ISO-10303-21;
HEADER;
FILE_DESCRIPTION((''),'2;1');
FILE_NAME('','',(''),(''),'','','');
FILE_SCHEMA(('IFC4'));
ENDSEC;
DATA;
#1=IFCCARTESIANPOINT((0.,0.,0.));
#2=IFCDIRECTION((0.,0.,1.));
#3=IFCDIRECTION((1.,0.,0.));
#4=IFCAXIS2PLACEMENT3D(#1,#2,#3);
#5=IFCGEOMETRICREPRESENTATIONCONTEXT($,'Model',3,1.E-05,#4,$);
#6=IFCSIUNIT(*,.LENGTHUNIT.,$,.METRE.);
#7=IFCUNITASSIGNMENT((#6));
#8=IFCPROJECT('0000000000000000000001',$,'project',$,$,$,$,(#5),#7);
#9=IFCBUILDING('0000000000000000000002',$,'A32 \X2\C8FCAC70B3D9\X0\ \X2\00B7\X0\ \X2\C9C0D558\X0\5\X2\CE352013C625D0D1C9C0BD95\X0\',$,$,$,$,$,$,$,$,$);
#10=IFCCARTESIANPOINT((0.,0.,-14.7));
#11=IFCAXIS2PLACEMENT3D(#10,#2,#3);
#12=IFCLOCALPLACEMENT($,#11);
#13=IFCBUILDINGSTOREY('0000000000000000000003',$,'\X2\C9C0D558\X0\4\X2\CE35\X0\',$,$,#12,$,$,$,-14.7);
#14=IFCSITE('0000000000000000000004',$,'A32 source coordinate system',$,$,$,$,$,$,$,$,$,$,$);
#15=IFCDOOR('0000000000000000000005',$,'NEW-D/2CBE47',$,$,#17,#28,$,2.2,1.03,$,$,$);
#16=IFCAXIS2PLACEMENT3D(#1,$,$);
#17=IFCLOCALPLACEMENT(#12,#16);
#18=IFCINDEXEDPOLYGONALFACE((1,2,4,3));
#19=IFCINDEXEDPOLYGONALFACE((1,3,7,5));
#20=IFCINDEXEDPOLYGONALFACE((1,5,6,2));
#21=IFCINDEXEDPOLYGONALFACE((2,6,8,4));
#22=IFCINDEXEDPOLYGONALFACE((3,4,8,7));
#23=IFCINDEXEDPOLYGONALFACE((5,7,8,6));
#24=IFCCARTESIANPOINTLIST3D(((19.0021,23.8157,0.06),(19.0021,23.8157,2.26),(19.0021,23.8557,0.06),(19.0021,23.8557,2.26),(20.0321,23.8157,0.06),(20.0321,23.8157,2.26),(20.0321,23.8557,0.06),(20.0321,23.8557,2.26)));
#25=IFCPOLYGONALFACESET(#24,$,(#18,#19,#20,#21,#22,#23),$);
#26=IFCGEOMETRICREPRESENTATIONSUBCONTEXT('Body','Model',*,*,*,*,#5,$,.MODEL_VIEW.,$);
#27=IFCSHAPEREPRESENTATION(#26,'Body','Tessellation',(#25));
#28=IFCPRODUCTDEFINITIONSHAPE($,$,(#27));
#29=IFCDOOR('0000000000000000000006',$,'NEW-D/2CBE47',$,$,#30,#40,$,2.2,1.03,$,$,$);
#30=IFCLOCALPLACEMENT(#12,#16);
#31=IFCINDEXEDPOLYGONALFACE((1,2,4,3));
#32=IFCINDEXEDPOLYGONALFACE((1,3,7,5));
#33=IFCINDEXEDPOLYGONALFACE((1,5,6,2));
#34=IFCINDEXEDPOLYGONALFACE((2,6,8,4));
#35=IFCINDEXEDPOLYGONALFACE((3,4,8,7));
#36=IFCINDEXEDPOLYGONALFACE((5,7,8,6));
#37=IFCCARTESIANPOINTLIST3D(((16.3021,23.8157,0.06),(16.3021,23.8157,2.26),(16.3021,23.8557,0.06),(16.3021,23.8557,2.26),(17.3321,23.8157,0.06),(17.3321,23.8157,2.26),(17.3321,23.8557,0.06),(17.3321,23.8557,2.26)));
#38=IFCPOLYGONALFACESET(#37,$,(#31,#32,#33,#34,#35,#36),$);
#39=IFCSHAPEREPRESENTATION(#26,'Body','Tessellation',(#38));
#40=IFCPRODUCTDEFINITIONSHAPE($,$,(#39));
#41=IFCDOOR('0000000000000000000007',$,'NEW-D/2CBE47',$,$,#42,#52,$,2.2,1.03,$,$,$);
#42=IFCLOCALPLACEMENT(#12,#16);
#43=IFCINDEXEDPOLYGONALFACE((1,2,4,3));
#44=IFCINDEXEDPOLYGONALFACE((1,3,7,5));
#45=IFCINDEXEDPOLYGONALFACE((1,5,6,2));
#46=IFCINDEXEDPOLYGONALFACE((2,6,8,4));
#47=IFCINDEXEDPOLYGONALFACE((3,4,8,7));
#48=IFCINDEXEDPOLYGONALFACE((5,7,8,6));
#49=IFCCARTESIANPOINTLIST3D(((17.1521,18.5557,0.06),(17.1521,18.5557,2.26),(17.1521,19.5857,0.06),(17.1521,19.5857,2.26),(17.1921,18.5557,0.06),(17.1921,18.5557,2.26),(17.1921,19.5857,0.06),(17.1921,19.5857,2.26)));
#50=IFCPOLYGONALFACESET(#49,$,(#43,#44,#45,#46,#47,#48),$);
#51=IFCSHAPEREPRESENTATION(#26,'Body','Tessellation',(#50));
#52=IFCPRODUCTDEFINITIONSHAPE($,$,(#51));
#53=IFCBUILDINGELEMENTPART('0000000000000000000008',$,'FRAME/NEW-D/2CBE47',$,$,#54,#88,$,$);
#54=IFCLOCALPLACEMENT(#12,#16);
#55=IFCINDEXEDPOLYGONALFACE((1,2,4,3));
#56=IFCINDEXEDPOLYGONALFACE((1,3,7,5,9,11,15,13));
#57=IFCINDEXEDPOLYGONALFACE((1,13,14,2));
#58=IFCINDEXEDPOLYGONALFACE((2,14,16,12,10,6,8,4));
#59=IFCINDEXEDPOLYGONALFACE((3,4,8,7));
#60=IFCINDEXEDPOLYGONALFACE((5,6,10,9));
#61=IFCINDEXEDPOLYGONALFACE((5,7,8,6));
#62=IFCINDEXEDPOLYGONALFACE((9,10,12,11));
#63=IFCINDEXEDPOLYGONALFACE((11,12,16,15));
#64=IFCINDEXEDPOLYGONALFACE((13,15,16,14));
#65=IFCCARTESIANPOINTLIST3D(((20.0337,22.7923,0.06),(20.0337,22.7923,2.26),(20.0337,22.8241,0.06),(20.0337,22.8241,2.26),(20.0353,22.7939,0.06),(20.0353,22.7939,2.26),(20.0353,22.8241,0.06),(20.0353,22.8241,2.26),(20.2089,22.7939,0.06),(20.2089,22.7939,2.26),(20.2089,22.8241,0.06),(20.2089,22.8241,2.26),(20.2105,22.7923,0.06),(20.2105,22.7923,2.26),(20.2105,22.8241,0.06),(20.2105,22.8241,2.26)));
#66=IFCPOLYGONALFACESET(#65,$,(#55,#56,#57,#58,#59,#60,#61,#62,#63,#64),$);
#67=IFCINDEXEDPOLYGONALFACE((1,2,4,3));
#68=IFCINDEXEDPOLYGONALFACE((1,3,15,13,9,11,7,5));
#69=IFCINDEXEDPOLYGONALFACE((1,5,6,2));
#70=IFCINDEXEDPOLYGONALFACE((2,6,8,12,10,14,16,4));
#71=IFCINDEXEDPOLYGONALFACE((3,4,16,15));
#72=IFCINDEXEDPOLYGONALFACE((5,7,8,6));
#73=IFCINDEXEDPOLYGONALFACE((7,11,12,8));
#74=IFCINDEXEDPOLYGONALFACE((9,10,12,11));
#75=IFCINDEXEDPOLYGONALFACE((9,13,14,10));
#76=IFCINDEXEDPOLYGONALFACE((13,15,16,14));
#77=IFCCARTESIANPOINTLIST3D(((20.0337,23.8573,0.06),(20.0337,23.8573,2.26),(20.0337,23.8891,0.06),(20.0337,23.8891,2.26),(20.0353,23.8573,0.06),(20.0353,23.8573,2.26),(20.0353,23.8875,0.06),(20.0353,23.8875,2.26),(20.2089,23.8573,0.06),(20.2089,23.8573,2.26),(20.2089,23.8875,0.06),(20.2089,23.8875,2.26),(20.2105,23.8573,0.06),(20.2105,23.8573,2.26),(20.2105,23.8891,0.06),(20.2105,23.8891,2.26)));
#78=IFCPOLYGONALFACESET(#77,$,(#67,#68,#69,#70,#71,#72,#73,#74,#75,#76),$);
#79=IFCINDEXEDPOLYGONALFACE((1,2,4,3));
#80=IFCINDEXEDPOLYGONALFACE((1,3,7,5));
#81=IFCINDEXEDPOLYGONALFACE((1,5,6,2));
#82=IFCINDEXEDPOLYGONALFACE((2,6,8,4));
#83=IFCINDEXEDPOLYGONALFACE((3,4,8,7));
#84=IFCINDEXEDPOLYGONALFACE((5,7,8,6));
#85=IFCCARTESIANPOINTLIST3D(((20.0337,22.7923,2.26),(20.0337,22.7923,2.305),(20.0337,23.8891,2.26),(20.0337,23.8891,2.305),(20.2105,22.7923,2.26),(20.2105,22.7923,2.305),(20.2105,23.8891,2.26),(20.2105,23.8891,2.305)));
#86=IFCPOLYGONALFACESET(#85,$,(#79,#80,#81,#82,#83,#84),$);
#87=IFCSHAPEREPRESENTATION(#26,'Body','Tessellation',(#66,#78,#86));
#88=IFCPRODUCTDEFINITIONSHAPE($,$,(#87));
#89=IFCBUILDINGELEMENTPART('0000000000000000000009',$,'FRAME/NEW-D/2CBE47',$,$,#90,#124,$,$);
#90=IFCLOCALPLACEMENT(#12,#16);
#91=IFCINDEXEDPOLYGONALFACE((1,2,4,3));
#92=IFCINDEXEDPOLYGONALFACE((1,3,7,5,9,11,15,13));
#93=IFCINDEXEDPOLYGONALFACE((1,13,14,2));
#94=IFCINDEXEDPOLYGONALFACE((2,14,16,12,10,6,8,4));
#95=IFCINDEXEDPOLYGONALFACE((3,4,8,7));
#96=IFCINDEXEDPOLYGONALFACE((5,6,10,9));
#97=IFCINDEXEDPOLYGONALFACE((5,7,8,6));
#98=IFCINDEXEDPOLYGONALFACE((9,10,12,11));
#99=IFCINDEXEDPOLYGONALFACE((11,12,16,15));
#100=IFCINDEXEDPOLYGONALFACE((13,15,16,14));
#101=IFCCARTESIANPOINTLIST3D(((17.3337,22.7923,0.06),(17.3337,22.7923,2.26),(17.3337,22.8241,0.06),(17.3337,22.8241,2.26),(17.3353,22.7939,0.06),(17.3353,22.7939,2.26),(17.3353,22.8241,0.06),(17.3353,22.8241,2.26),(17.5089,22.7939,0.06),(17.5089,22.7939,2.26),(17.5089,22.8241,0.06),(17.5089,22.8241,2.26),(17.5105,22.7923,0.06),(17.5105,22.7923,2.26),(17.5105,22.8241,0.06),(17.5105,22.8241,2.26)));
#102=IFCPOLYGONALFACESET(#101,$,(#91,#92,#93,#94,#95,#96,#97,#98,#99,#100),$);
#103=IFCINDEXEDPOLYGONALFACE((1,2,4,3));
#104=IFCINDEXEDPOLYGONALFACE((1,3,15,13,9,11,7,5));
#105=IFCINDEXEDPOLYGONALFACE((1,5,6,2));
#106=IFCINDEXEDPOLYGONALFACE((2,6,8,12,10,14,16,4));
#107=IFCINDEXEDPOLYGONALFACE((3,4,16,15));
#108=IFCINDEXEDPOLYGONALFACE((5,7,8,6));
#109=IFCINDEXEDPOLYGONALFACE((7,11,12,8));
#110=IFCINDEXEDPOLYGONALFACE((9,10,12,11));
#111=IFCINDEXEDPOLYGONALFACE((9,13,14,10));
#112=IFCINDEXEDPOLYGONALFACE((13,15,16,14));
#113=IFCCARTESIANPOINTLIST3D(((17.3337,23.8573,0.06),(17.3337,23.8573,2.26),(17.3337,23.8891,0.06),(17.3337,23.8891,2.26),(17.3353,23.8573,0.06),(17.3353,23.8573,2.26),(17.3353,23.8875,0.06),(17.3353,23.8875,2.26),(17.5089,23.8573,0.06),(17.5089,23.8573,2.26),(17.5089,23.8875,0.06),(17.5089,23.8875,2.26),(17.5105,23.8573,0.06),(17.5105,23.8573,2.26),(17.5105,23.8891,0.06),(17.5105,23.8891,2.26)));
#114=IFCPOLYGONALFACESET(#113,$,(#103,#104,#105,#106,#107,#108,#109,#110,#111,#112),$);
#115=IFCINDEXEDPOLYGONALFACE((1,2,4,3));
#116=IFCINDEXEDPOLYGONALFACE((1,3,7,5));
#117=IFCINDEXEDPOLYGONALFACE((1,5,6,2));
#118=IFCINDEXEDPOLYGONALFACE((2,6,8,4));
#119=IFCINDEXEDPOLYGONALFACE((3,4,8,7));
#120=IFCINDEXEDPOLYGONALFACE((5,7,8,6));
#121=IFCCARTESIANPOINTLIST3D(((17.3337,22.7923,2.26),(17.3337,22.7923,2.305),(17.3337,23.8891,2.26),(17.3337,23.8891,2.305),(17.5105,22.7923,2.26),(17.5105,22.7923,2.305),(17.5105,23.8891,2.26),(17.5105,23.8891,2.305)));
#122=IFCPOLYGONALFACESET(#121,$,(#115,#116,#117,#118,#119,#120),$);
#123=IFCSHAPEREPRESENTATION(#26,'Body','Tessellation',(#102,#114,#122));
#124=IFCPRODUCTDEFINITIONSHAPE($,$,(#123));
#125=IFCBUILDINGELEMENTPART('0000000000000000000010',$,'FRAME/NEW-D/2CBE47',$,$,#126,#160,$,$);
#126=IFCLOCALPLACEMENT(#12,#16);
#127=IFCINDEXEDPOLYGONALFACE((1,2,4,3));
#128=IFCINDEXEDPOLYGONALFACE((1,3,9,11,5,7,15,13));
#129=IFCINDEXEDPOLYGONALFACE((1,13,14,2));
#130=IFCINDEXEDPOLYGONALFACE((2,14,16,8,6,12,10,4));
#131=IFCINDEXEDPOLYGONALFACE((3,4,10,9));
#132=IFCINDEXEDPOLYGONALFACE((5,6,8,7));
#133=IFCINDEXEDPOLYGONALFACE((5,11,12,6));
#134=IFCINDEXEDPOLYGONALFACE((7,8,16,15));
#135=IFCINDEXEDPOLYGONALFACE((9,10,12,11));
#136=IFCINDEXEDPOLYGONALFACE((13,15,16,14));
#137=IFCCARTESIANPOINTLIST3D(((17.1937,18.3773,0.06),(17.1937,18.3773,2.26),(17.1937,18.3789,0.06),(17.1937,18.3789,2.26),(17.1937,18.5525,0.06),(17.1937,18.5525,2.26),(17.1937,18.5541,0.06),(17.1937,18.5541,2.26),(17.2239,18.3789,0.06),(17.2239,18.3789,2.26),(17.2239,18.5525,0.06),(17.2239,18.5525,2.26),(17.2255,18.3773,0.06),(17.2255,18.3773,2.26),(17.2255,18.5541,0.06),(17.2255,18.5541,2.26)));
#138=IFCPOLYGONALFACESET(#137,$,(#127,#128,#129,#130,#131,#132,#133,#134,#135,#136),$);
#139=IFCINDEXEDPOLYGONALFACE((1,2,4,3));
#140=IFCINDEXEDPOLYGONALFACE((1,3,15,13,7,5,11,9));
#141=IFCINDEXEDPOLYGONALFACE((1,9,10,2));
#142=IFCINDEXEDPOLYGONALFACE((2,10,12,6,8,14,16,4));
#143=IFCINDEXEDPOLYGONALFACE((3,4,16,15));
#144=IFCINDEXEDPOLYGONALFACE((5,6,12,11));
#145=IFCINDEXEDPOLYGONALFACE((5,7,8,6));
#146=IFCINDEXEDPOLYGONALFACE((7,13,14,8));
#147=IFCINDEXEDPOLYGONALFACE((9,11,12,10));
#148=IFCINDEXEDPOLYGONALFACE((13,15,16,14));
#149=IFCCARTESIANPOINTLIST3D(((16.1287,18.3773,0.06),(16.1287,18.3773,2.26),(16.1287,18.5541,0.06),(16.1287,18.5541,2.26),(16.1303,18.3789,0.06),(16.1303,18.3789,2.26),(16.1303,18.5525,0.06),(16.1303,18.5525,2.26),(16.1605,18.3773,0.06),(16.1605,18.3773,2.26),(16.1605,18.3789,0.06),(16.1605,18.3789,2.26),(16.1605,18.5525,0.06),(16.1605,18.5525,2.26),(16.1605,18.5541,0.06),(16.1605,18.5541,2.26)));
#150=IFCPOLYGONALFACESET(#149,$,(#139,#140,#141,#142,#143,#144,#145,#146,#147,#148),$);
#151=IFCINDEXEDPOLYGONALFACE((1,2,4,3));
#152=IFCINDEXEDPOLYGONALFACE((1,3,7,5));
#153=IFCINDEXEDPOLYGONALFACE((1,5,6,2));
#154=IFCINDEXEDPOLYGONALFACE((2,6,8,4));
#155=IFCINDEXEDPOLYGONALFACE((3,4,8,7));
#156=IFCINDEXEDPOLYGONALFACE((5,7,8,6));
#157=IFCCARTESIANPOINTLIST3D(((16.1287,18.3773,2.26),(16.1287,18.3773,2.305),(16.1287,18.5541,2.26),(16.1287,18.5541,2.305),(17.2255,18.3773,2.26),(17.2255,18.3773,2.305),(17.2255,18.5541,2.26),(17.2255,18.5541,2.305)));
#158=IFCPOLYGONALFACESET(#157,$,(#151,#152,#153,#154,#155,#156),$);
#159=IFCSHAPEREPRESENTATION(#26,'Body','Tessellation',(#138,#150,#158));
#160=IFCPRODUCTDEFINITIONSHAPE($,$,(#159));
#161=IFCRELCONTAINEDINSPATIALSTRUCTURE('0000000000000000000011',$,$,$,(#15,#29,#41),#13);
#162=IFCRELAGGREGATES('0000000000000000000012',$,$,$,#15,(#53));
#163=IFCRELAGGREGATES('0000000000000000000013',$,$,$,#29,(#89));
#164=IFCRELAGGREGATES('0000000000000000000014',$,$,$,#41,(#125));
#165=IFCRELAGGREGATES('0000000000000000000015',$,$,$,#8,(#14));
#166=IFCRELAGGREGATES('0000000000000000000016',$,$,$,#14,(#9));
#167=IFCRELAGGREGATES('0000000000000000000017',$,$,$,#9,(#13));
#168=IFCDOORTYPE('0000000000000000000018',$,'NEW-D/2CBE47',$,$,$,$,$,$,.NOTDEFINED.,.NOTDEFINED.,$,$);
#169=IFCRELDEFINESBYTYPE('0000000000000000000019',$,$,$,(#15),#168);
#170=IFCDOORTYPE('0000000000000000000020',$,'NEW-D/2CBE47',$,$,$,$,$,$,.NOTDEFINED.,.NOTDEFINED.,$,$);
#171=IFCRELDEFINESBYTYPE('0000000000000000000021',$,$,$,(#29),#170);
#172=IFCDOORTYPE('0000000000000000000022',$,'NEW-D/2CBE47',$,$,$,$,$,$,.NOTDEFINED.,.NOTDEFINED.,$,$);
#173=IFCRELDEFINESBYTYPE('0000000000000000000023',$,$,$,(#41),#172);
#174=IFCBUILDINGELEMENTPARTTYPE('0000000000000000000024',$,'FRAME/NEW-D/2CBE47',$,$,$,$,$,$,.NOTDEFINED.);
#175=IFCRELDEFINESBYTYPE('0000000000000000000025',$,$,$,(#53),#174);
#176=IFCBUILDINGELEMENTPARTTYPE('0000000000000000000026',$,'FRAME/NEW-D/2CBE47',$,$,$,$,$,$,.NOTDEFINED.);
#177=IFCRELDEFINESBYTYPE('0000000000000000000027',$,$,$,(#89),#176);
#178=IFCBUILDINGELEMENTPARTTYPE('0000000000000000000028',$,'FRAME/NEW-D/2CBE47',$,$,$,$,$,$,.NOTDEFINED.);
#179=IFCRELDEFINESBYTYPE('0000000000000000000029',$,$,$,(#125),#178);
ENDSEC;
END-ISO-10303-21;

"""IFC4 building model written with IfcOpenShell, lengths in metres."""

from ifc_helpers import new_model, si_unit, frame, origin, origin_with_axes, place, context, subcontext, project, spatial, polyline, outline, extrude, source, transform, mapped, type_object, type_shapes, element, aggregate, save


model = new_model("IFC4")

# Units and contexts
model_context = context("Model", 3, precision=1e-05, world=origin_with_axes())
body_context = subcontext(model_context, "Body", "Model", "MODEL_VIEW")
ifc_project = project(units=[si_unit("LENGTHUNIT", "METRE")], contexts=[model_context])

# Site, building, storey
site = spatial("IfcSite", under=ifc_project, Name="A32 source coordinate system")
building = spatial("IfcBuilding", under=site, Name="A32 주거동 · 지하5층–옥탑지붕")
storey_placement = place(None, frame((0.0, 0.0, -14.7), z_axis=(0.0, 0.0, 1.0), x_axis=(1.0, 0.0, 0.0)))
storey = spatial("IfcBuildingStorey", under=building, at=storey_placement, Name="지하4층", Elevation=-14.7)

# Doors
door_type_1 = type_object("IfcDoorType", Name="NEW-D/2CBE47", OperationType="NOTDEFINED", PredefinedType="NOTDEFINED")
shared_shape_1 = source(origin(), body_context, "Body", "SweptSolid", [
    extrude(outline(polyline([(20.0321, 23.8557), (20.0321, 23.8157), (19.0021, 23.8157), (19.0021, 23.8557), (20.0321, 23.8557)])), frame((0.0, 0.0, 0.06)), (0.0, 0.0, 1.0), 2.2),
])
type_shapes(door_type_1, [shared_shape_1])
door_1_placement = place(storey_placement, origin_with_axes())
door_1 = element("IfcDoor", 1, at=door_1_placement, inside=storey, type_object=door_type_1, Name="NEW-D/2CBE47", OverallHeight=2.2, OverallWidth=1.03, context=body_context, shape_type="MappedRepresentation", body=[
    mapped(shared_shape_1, transform((0.0, 0.0, 0.0), scale=1.0)),
])
door_type_2 = type_object("IfcDoorType", Name="NEW-D/2CBE47", OperationType="NOTDEFINED", PredefinedType="NOTDEFINED")
shared_shape_2 = source(origin(), body_context, "Body", "SweptSolid", [
    extrude(outline(polyline([(17.3321, 23.8557), (17.3321, 23.8157), (16.3021, 23.8157), (16.3021, 23.8557), (17.3321, 23.8557)])), frame((0.0, 0.0, 0.06)), (0.0, 0.0, 1.0), 2.2),
])
type_shapes(door_type_2, [shared_shape_2])
door_2_placement = place(storey_placement, origin_with_axes())
door_2 = element("IfcDoor", 2, at=door_2_placement, inside=storey, type_object=door_type_2, Name="NEW-D/2CBE47", OverallHeight=2.2, OverallWidth=1.03, context=body_context, shape_type="MappedRepresentation", body=[
    mapped(shared_shape_2, transform((0.0, 0.0, 0.0), scale=1.0)),
])
door_type_3 = type_object("IfcDoorType", Name="NEW-D/2CBE47", OperationType="NOTDEFINED", PredefinedType="NOTDEFINED")
shared_shape_3 = source(origin(), body_context, "Body", "SweptSolid", [
    extrude(outline(polyline([(17.1921, 18.5557), (17.1521, 18.5557), (17.1521, 19.5857), (17.1921, 19.5857), (17.1921, 18.5557)])), frame((0.0, 0.0, 0.06)), (0.0, 0.0, 1.0), 2.2),
])
type_shapes(door_type_3, [shared_shape_3])
door_3_placement = place(storey_placement, origin_with_axes())
door_3 = element("IfcDoor", 3, at=door_3_placement, inside=storey, type_object=door_type_3, Name="NEW-D/2CBE47", OverallHeight=2.2, OverallWidth=1.03, context=body_context, shape_type="MappedRepresentation", body=[
    mapped(shared_shape_3, transform((0.0, 0.0, 0.0), scale=1.0)),
])

# Building element parts
building_element_part_type_1 = type_object("IfcBuildingElementPartType", Name="FRAME/NEW-D/2CBE47", PredefinedType="NOTDEFINED")
shared_shape_4 = source(origin(), body_context, "Body", "SweptSolid", [
    extrude(outline(polyline([(20.0353, 22.7939), (20.2089, 22.7939), (20.2089, 22.8241), (20.2105, 22.8241), (20.2105, 22.7923), (20.0337, 22.7923), (20.0337, 22.8241), (20.0353, 22.8241), (20.0353, 22.7939)])), frame((0.0, 0.0, 0.06)), (0.0, 0.0, 1.0), 2.2),
    extrude(outline(polyline([(20.2105, 23.8891), (20.2105, 23.8573), (20.2089, 23.8573), (20.2089, 23.8875), (20.0353, 23.8875), (20.0353, 23.8573), (20.0337, 23.8573), (20.0337, 23.8891), (20.2105, 23.8891)])), frame((0.0, 0.0, 0.06)), (0.0, 0.0, 1.0), 2.2),
    extrude(outline(polyline([(20.2105, 22.7923), (20.2105, 23.8891), (20.0337, 23.8891), (20.0337, 22.7923), (20.2105, 22.7923)])), frame((0.0, 0.0, 2.26)), (0.0, 0.0, 1.0), 0.045),
])
type_shapes(building_element_part_type_1, [shared_shape_4])
building_element_part_1_placement = place(door_1_placement, origin_with_axes())
building_element_part_1 = element("IfcBuildingElementPart", 4, at=building_element_part_1_placement, type_object=building_element_part_type_1, Name="FRAME/NEW-D/2CBE47", context=body_context, shape_type="MappedRepresentation", body=[
    mapped(shared_shape_4, transform((0.0, 0.0, 0.0), scale=1.0)),
])
aggregate(door_1, [building_element_part_1])
building_element_part_type_2 = type_object("IfcBuildingElementPartType", Name="FRAME/NEW-D/2CBE47", PredefinedType="NOTDEFINED")
shared_shape_5 = source(origin(), body_context, "Body", "SweptSolid", [
    extrude(outline(polyline([(17.3353, 22.7939), (17.5089, 22.7939), (17.5089, 22.8241), (17.5105, 22.8241), (17.5105, 22.7923), (17.3337, 22.7923), (17.3337, 22.8241), (17.3353, 22.8241), (17.3353, 22.7939)])), frame((0.0, 0.0, 0.06)), (0.0, 0.0, 1.0), 2.2),
    extrude(outline(polyline([(17.5105, 23.8891), (17.5105, 23.8573), (17.5089, 23.8573), (17.5089, 23.8875), (17.3353, 23.8875), (17.3353, 23.8573), (17.3337, 23.8573), (17.3337, 23.8891), (17.5105, 23.8891)])), frame((0.0, 0.0, 0.06)), (0.0, 0.0, 1.0), 2.2),
    extrude(outline(polyline([(17.5105, 22.7923), (17.5105, 23.8891), (17.3337, 23.8891), (17.3337, 22.7923), (17.5105, 22.7923)])), frame((0.0, 0.0, 2.26)), (0.0, 0.0, 1.0), 0.045),
])
type_shapes(building_element_part_type_2, [shared_shape_5])
building_element_part_2_placement = place(door_2_placement, origin_with_axes())
building_element_part_2 = element("IfcBuildingElementPart", 5, at=building_element_part_2_placement, type_object=building_element_part_type_2, Name="FRAME/NEW-D/2CBE47", context=body_context, shape_type="MappedRepresentation", body=[
    mapped(shared_shape_5, transform((0.0, 0.0, 0.0), scale=1.0)),
])
aggregate(door_2, [building_element_part_2])
building_element_part_type_3 = type_object("IfcBuildingElementPartType", Name="FRAME/NEW-D/2CBE47", PredefinedType="NOTDEFINED")
shared_shape_6 = source(origin(), body_context, "Body", "SweptSolid", [
    extrude(outline(polyline([(17.2255, 18.3773), (17.1937, 18.3773), (17.1937, 18.3789), (17.2239, 18.3789), (17.2239, 18.5525), (17.1937, 18.5525), (17.1937, 18.5541), (17.2255, 18.5541), (17.2255, 18.3773)])), frame((0.0, 0.0, 0.06)), (0.0, 0.0, 1.0), 2.2),
    extrude(outline(polyline([(16.1303, 18.5525), (16.1303, 18.3789), (16.1605, 18.3789), (16.1605, 18.3773), (16.1287, 18.3773), (16.1287, 18.5541), (16.1605, 18.5541), (16.1605, 18.5525), (16.1303, 18.5525)])), frame((0.0, 0.0, 0.06)), (0.0, 0.0, 1.0), 2.2),
    extrude(outline(polyline([(17.2255, 18.3773), (17.2255, 18.5541), (16.1287, 18.5541), (16.1287, 18.3773), (17.2255, 18.3773)])), frame((0.0, 0.0, 2.26)), (0.0, 0.0, 1.0), 0.045),
])
type_shapes(building_element_part_type_3, [shared_shape_6])
building_element_part_3_placement = place(door_3_placement, origin_with_axes())
building_element_part_3 = element("IfcBuildingElementPart", 6, at=building_element_part_3_placement, type_object=building_element_part_type_3, Name="FRAME/NEW-D/2CBE47", context=body_context, shape_type="MappedRepresentation", body=[
    mapped(shared_shape_6, transform((0.0, 0.0, 0.0), scale=1.0)),
])
aggregate(door_3, [building_element_part_3])

save(model, "model.ifc")
